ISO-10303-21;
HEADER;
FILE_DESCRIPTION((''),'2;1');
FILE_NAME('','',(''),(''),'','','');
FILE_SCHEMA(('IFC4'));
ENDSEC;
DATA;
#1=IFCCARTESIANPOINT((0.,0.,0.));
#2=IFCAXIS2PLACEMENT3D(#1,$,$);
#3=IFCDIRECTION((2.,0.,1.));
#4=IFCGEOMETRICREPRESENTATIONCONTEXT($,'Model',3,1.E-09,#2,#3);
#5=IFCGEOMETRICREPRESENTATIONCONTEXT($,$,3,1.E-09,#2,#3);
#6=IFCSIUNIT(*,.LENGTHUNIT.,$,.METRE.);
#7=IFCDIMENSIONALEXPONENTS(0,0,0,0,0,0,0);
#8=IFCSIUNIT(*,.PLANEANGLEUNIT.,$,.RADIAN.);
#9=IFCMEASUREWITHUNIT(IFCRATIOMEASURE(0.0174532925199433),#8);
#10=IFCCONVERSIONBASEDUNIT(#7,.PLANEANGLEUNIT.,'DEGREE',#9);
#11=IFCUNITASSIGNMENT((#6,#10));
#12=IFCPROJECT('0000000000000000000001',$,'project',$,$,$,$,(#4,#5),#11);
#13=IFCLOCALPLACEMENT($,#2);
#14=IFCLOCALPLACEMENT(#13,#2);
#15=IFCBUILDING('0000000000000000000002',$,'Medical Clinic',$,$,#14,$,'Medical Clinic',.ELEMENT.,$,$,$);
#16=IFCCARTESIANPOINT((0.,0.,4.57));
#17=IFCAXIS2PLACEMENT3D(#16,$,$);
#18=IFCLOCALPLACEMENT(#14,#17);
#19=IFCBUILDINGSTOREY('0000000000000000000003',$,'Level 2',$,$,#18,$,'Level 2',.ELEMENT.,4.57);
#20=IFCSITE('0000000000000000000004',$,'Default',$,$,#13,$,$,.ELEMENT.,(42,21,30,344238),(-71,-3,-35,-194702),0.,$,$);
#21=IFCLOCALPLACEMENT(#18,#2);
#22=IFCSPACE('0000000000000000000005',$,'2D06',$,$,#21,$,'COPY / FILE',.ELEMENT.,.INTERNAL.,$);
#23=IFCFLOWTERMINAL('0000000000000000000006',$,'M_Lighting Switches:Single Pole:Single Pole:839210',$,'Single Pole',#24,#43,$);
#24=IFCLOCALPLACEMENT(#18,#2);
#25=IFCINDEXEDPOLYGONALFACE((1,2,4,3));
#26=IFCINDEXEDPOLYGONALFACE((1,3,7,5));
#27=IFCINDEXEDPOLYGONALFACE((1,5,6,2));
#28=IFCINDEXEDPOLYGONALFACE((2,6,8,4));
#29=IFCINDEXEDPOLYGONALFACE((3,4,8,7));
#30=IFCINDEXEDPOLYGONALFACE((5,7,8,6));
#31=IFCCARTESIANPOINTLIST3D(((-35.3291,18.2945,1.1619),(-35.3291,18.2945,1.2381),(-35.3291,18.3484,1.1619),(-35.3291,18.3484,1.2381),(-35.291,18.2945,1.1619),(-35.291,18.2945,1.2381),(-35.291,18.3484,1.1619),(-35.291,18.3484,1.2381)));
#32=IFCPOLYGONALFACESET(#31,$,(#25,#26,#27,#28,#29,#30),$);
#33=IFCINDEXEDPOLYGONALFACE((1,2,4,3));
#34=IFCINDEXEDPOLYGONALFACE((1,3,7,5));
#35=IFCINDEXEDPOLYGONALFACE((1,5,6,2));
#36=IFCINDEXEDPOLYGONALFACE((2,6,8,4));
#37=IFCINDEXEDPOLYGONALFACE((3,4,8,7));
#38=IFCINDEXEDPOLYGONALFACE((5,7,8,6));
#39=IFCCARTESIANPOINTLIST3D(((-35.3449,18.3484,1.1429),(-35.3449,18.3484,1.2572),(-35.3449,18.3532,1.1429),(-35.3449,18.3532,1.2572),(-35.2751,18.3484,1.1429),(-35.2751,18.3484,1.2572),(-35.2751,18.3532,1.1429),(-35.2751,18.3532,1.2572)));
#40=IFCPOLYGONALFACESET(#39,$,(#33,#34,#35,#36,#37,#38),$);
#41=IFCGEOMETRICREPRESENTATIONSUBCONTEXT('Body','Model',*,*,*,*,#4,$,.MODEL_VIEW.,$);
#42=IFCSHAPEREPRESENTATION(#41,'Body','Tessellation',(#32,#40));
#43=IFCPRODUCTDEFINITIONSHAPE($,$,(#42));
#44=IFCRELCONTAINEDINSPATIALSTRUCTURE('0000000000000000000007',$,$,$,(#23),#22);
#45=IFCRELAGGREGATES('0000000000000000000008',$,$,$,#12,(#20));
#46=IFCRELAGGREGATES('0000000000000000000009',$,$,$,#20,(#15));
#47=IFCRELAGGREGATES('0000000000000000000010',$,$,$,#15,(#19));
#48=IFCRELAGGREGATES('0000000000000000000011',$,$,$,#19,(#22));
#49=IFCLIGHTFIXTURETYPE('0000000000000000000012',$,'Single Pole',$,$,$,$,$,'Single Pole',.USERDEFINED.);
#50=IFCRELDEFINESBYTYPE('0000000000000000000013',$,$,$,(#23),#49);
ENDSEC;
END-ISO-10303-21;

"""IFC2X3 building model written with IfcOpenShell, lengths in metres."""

from ifc_helpers import new_model, entity, si_unit, converted_unit, direction, frame, frame_2d, origin, origin_2d_with_axis, place, context, subcontext, project, spatial, rectangle, extrude, source, transform, mapped, type_object, type_shapes, element, save


model = new_model("IFC2X3")

# Units and contexts
model_context = context("Model", 3, precision=1e-09, world=origin(), true_north=direction((2.0, 0.0, 1.0)))
context_of_model = context(None, 3, precision=1e-09, world=origin(), true_north=direction((2.0, 0.0, 1.0)))
body_context = subcontext(model_context, "Body", "Model", "MODEL_VIEW")
ifc_project = project(units=[si_unit("LENGTHUNIT", "METRE"), converted_unit("PLANEANGLEUNIT", "DEGREE", entity("IfcRatioMeasure", 0.0174532925199433), si_unit("PLANEANGLEUNIT", "RADIAN"), dimensions=[0, 0, 0, 0, 0, 0, 0])], contexts=[model_context, context_of_model])

# Site, building, storey
site_placement = place(None, origin())
site = spatial("IfcSite", under=ifc_project, at=site_placement, Name="Default", CompositionType="ELEMENT", RefLatitude=(42, 21, 30, 344238), RefLongitude=(-71, -3, -35, -194702), RefElevation=0.0)
building_placement = place(site_placement, origin())
building = spatial("IfcBuilding", under=site, at=building_placement, Name="Medical Clinic", LongName="Medical Clinic", CompositionType="ELEMENT")
storey_placement = place(building_placement, frame((0.0, 0.0, 4.57)))
storey = spatial("IfcBuildingStorey", under=building, at=storey_placement, Name="Level 2", LongName="Level 2", CompositionType="ELEMENT", Elevation=4.57)

# Shared definitions
space_1_placement = place(storey_placement, origin())
space_1 = spatial("IfcSpace", under=storey, at=space_1_placement, Name="2D06", LongName="COPY / FILE", CompositionType="ELEMENT", InteriorOrExteriorSpace="INTERNAL")

# Flow terminal
light_fixture_type_1 = type_object("IfcLightFixtureType", Name="Single Pole", ElementType="Single Pole", PredefinedType="USERDEFINED")
shared_shape_1 = source(origin(), body_context, "Body", "SweptSolid", [
    extrude(rectangle(XDim=0.0381, YDim=0.0762, at=origin_2d_with_axis()), frame((0.0, 0.0, -0.054), z_axis=(0.0, 0.0, 1.0), x_axis=(-1.0, 0.0, 0.0)), (0.0, 0.0, 1.0), 0.054),
    extrude(rectangle(XDim=0.0698, YDim=0.1143, at=frame_2d((0.0, 0.0), x_axis=(1.0, 0.0))), frame((0.0, 0.0, 0.0), z_axis=(0.0, 0.0, 1.0), x_axis=(-1.0, 0.0, 0.0)), (0.0, 0.0, 1.0), 0.0048),
])
type_shapes(light_fixture_type_1, [shared_shape_1])
flow_terminal_1_placement = place(space_1_placement, frame((-35.31, 18.3484, 1.2), z_axis=(0.0, 1.0, 0.0), x_axis=(-1.0, 0.0, 0.0)))
element("IfcFlowTerminal", 1, at=flow_terminal_1_placement, inside=space_1, type_object=light_fixture_type_1, Name="M_Lighting Switches:Single Pole:Single Pole:839210", ObjectType="Single Pole", context=body_context, shape_type="MappedRepresentation", body=[
    mapped(shared_shape_1, transform((0.0, 0.0, 0.0), scale=1.0)),
])

save(model, "model.ifc")
